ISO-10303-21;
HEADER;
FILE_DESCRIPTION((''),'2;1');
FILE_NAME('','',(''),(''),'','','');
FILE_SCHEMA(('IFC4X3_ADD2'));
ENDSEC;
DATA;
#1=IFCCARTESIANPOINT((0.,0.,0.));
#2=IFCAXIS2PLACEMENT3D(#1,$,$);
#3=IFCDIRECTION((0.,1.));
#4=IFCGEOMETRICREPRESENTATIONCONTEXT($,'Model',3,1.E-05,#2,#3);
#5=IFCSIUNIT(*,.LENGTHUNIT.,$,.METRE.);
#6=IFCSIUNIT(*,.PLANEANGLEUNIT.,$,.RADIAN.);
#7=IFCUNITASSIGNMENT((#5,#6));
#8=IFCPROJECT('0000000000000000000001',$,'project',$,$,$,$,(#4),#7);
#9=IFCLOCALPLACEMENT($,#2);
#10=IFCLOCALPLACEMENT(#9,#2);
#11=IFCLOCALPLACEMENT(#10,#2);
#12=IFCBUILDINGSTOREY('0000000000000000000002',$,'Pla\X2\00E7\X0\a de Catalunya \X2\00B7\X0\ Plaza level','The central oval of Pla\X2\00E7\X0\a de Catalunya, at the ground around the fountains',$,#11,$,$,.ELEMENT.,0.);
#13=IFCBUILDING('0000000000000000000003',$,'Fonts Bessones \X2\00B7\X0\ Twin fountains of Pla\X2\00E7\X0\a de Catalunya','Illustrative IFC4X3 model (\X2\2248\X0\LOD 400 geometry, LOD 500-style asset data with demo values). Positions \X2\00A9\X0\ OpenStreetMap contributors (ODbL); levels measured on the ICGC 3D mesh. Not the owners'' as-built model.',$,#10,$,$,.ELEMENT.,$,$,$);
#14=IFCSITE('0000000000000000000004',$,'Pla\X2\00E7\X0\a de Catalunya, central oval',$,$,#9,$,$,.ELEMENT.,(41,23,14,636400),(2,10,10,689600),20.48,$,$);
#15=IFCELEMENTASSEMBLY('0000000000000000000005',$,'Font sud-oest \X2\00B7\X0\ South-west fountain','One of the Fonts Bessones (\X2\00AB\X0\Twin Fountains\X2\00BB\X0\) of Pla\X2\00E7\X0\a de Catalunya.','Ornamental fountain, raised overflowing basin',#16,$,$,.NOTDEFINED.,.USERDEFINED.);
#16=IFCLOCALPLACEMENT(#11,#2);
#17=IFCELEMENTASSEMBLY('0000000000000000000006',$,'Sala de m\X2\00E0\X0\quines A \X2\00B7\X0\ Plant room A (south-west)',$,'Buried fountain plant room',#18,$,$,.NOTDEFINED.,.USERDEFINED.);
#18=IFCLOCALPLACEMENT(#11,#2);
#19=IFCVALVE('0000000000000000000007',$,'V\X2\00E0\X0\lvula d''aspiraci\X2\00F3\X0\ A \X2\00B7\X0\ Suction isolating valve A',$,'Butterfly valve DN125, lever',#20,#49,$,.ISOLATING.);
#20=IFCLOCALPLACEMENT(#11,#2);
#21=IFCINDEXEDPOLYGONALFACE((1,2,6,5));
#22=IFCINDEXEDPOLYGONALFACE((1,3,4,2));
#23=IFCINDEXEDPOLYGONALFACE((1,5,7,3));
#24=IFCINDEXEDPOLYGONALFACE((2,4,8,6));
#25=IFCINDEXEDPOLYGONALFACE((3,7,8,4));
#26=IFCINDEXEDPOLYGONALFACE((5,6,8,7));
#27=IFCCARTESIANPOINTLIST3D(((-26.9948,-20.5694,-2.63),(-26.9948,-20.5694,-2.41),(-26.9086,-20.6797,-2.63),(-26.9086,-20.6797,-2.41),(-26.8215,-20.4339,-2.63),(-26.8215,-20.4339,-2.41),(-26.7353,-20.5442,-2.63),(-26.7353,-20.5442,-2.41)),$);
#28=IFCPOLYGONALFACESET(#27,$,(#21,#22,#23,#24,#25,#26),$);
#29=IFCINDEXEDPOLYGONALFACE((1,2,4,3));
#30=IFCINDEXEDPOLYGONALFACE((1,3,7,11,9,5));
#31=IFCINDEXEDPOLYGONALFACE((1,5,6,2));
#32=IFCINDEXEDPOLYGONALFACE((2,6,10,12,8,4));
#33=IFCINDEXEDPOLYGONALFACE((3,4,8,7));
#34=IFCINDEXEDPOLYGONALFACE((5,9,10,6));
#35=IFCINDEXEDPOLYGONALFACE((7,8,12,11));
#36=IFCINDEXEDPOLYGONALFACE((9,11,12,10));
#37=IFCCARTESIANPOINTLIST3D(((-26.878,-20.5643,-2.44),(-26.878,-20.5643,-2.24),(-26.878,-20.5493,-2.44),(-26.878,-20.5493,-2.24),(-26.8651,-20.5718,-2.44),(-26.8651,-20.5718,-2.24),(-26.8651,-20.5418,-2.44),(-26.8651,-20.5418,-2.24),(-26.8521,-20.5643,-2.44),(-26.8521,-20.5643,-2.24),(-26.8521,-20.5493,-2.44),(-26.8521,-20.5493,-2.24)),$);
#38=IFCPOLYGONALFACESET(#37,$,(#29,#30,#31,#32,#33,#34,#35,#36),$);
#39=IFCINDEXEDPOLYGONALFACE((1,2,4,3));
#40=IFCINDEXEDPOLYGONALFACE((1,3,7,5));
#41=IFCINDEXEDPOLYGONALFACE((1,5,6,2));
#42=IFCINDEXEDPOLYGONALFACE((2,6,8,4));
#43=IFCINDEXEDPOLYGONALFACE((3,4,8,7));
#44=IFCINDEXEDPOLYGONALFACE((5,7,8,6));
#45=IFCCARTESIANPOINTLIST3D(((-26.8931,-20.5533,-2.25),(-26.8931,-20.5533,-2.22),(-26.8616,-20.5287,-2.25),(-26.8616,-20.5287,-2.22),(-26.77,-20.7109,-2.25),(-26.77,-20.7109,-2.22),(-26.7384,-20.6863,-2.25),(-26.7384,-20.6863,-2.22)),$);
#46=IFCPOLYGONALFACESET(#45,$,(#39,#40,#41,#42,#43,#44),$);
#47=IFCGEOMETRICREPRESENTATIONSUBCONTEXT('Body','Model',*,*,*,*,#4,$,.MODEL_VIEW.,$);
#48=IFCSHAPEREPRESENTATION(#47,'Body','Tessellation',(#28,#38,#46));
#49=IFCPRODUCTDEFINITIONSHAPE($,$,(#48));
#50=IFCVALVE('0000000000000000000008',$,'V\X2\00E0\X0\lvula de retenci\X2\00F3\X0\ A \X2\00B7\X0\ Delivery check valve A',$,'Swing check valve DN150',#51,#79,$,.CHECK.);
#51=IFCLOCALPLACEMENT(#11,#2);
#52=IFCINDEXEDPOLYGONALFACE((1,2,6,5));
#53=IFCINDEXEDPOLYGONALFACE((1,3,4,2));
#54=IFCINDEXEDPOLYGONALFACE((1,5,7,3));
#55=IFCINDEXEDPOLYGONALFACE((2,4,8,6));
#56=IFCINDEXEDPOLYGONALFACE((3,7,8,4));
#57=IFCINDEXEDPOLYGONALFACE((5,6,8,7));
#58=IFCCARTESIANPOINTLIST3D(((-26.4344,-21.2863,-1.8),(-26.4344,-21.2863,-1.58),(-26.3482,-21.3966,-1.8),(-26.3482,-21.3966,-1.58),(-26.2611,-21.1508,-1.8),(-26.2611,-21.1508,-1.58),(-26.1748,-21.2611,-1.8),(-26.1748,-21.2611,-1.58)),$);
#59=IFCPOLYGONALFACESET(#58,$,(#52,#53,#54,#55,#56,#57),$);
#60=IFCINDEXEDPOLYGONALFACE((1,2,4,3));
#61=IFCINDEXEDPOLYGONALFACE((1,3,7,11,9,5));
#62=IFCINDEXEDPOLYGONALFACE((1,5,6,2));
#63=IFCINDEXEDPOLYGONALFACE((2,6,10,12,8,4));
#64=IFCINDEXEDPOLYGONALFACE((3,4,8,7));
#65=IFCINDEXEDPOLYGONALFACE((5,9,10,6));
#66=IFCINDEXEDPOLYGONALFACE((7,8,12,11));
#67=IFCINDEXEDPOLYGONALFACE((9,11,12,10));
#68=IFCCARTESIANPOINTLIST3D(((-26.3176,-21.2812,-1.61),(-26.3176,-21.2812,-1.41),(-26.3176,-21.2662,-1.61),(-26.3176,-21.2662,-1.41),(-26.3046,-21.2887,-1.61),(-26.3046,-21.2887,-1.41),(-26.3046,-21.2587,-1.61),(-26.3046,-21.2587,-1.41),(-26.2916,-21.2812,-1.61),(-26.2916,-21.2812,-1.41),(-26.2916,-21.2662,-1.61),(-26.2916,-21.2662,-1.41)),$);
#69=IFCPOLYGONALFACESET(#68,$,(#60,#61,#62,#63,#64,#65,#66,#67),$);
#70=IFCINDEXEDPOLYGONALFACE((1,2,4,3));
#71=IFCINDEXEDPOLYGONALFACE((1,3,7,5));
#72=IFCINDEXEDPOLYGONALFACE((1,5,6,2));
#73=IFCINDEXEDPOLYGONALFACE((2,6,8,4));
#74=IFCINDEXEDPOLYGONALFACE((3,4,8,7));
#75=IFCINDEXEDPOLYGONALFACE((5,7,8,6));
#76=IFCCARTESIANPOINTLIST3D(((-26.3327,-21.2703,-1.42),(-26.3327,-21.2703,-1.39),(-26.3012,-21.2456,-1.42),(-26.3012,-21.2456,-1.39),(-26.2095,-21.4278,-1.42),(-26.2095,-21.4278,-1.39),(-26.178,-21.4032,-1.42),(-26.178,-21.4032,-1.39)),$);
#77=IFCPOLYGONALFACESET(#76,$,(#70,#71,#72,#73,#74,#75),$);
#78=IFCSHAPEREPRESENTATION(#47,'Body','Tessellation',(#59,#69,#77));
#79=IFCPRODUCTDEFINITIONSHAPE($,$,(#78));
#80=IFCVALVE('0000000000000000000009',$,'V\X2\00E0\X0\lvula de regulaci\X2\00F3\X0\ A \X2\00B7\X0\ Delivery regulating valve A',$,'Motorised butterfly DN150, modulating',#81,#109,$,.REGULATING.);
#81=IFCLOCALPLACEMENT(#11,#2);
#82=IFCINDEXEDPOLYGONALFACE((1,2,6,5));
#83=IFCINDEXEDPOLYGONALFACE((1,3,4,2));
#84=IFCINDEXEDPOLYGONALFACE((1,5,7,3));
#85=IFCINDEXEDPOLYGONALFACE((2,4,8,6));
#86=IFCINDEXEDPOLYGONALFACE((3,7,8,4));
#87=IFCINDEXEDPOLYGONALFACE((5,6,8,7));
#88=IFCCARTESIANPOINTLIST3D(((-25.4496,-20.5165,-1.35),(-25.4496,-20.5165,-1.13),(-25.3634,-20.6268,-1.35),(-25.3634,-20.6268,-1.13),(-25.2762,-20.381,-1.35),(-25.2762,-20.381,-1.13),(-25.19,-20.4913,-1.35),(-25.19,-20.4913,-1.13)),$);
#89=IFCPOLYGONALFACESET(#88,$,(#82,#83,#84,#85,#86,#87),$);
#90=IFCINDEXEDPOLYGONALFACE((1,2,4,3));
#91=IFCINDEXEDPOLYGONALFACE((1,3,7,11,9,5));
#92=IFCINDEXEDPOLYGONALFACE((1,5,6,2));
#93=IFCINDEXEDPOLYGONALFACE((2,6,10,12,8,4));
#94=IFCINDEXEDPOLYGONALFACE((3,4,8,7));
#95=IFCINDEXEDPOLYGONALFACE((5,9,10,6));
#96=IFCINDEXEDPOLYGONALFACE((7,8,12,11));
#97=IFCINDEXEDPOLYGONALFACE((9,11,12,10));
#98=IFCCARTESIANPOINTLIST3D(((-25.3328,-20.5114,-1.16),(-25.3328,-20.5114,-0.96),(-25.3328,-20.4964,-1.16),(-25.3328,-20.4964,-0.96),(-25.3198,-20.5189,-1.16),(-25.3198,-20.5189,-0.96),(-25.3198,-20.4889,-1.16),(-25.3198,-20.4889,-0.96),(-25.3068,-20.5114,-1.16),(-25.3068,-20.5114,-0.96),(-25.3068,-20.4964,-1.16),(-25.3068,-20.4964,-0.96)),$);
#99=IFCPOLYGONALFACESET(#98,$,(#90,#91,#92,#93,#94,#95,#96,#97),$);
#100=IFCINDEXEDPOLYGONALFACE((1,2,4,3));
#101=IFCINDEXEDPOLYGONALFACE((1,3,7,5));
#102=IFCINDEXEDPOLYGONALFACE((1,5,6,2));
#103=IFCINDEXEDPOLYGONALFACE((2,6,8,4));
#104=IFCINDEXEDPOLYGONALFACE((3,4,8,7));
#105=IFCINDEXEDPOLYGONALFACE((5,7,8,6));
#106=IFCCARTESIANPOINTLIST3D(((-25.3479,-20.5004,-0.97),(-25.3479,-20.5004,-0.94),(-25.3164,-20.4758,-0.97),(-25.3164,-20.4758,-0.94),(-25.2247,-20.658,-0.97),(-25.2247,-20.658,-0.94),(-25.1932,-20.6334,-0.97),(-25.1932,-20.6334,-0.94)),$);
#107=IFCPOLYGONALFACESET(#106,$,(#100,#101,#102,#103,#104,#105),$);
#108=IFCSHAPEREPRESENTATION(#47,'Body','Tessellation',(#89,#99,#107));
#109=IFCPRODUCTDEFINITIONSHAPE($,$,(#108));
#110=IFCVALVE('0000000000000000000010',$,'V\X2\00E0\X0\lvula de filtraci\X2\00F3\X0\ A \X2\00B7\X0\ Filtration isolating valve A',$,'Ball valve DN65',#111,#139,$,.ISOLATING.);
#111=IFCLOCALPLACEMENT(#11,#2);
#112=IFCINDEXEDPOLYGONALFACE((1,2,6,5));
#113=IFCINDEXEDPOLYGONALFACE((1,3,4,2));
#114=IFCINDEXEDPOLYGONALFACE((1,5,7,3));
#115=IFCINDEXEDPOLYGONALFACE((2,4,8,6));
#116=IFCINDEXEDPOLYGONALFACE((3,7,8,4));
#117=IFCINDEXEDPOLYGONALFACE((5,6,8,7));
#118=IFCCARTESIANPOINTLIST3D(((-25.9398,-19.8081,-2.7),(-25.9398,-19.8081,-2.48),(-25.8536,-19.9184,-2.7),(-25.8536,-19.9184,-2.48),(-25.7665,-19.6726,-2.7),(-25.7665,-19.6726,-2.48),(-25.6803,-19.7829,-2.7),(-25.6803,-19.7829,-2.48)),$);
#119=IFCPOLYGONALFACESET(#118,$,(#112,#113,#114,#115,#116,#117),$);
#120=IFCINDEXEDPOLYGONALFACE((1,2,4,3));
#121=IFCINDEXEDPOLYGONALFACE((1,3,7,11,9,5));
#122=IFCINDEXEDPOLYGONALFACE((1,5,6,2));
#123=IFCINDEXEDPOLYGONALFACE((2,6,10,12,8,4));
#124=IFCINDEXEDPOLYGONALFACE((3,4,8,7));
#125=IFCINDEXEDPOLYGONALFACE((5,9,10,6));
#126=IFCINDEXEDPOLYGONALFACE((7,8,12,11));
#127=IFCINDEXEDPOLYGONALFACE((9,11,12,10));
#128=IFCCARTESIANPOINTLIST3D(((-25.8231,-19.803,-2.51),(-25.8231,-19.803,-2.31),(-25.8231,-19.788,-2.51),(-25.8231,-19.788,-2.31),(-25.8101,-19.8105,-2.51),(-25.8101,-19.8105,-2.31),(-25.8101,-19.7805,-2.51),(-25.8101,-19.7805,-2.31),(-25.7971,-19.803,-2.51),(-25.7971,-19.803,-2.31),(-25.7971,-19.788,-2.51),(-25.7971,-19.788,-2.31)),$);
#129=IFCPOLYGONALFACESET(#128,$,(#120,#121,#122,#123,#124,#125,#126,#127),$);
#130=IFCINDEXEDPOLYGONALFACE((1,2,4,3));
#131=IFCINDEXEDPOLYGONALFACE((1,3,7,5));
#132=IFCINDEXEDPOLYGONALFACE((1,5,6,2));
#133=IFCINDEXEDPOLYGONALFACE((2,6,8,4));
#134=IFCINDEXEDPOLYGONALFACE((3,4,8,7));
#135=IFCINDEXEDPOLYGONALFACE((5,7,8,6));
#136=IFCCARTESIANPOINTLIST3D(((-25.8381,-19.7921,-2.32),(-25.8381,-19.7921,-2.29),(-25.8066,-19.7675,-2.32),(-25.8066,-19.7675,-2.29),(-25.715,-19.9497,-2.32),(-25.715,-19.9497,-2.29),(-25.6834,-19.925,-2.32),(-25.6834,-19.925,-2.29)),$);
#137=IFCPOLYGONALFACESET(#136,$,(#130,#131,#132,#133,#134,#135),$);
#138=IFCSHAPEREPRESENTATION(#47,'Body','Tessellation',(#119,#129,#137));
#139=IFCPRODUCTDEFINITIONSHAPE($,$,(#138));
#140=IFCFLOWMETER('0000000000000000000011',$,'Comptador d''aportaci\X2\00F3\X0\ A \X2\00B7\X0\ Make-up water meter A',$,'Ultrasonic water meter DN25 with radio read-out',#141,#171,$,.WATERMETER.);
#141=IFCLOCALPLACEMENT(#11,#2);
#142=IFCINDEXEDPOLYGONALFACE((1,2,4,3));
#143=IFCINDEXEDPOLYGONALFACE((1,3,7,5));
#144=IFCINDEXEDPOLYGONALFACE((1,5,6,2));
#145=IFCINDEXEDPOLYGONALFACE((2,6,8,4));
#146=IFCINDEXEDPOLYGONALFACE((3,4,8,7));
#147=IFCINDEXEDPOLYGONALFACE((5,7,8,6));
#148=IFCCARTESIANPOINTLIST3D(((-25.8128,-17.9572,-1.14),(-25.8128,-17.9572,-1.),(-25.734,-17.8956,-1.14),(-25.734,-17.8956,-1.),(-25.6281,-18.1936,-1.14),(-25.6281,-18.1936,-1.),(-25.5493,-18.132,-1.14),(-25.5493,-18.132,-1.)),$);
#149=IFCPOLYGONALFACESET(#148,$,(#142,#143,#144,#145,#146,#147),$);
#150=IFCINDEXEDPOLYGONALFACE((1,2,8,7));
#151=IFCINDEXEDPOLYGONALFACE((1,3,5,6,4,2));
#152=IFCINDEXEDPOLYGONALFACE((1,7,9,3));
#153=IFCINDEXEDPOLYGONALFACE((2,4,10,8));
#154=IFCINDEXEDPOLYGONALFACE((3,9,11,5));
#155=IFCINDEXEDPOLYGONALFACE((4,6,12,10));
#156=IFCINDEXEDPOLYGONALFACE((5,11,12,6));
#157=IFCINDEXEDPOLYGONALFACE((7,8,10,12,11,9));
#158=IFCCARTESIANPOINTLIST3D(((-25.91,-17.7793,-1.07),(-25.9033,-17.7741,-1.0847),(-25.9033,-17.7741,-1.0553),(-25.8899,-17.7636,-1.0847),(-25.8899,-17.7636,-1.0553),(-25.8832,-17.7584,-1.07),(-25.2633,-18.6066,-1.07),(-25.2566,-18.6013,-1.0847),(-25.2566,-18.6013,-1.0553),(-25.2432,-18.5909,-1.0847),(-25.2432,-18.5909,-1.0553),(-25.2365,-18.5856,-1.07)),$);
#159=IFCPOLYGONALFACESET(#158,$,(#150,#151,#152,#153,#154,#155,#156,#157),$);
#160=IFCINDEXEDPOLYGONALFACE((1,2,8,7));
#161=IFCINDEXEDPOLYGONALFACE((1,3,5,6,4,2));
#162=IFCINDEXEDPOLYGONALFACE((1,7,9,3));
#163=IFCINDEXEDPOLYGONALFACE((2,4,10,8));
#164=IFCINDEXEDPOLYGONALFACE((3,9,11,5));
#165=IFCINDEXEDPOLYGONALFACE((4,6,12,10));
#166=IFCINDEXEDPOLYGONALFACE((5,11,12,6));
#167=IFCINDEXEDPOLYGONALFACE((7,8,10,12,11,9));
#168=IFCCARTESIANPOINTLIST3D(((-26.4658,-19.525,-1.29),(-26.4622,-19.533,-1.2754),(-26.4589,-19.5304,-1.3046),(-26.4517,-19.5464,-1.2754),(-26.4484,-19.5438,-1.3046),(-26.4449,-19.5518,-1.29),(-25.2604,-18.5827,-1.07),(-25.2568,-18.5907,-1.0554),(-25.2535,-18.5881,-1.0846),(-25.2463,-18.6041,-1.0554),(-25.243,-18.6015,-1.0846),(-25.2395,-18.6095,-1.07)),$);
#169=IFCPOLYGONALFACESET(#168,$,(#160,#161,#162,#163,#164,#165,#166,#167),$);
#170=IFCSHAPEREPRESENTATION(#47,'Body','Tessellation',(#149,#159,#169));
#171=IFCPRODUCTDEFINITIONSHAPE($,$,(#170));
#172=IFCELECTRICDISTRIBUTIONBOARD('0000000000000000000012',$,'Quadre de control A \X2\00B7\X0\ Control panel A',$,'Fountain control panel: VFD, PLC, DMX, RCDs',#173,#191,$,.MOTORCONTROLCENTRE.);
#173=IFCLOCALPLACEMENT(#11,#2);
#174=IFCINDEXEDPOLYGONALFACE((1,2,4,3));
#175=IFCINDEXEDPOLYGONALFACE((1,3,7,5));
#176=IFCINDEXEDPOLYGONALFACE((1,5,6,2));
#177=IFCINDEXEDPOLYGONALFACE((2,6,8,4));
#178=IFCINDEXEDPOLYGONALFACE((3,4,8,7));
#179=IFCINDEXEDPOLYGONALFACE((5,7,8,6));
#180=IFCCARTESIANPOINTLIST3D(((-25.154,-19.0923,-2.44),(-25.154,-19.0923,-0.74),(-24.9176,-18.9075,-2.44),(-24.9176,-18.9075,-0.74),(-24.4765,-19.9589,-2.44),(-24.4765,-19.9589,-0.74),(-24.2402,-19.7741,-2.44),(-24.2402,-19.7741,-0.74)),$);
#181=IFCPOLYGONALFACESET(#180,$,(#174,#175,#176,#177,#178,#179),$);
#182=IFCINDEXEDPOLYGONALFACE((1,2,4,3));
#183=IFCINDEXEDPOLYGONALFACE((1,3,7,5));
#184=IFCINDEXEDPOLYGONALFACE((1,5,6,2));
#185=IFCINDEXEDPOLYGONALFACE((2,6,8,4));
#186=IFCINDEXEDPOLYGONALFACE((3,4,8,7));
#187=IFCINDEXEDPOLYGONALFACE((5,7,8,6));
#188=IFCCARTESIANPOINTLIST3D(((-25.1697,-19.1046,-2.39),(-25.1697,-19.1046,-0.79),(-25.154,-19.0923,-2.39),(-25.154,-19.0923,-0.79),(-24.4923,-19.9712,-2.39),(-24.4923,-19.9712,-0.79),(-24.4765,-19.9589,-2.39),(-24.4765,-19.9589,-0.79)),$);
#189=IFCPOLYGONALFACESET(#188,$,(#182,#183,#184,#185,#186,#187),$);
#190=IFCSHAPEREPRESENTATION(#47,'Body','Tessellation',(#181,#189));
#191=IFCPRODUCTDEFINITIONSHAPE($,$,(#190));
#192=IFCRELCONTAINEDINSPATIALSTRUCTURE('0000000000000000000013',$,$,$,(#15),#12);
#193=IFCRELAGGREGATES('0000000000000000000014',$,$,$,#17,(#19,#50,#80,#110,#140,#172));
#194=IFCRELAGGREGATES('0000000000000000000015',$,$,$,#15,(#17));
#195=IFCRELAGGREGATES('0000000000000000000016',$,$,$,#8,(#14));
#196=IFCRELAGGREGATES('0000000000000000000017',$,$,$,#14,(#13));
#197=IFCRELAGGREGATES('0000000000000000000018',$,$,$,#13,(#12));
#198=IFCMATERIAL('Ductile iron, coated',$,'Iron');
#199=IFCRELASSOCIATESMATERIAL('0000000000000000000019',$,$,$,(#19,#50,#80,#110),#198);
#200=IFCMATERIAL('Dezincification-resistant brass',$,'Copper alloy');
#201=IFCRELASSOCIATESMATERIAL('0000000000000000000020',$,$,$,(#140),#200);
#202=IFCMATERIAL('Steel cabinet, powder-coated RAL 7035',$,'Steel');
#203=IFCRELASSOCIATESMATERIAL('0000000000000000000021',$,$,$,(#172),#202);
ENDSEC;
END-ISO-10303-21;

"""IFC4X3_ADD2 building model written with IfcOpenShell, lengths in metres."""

from ifc_helpers import new_model, si_unit, direction, frame, frame_2d, origin, place, context, subcontext, project, spatial, polyline, rectangle, outline, extrude, material, element, aggregate, save


model = new_model("IFC4X3_ADD2")

# Units and contexts
model_context = context("Model", 3, precision=1e-05, world=origin(), true_north=direction((0.0, 1.0)))
body_context = subcontext(model_context, "Body", "Model", "MODEL_VIEW")
ifc_project = project(units=[si_unit("LENGTHUNIT", "METRE"), si_unit("PLANEANGLEUNIT", "RADIAN")], contexts=[model_context])

# Site, building, storey
site_placement = place(None, origin())
site = spatial("IfcSite", under=ifc_project, at=site_placement, Name="Plaça de Catalunya, central oval", CompositionType="ELEMENT", RefLatitude=(41, 23, 14, 636400), RefLongitude=(2, 10, 10, 689600), RefElevation=20.48)
building_placement = place(site_placement, origin())
building = spatial("IfcBuilding", under=site, at=building_placement, Name="Fonts Bessones · Twin fountains of Plaça de Catalunya", Description="Illustrative IFC4X3 model (≈LOD 400 geometry, LOD 500-style asset data with demo values). Positions © OpenStreetMap contributors (ODbL); levels measured on the ICGC 3D mesh. Not the owners' as-built model.", CompositionType="ELEMENT")
storey_placement = place(building_placement, origin())
storey = spatial("IfcBuildingStorey", under=building, at=storey_placement, Name="Plaça de Catalunya · Plaza level", Description="The central oval of Plaça de Catalunya, at the ground around the fountains", CompositionType="ELEMENT", Elevation=0.0)

# Element assemblies
assembly_1_placement = place(building_placement, origin())
assembly_1 = element("IfcElementAssembly", 1, at=assembly_1_placement, inside=storey, Name="Font sud-oest · South-west fountain", Description="One of the Fonts Bessones («Twin Fountains») of Plaça de Catalunya.", ObjectType="Ornamental fountain, raised overflowing basin", AssemblyPlace="NOTDEFINED", PredefinedType="USERDEFINED")
assembly_2_placement = place(building_placement, origin())
assembly_2 = element("IfcElementAssembly", 2, at=assembly_2_placement, Name="Sala de màquines A · Plant room A (south-west)", ObjectType="Buried fountain plant room", AssemblyPlace="NOTDEFINED", PredefinedType="USERDEFINED")

# Valves
ifc_material_1 = material(Name="Ductile iron, coated", Category="Iron")
valve_1_placement = place(building_placement, origin())
valve_1 = element("IfcValve", 3, at=valve_1_placement, material=ifc_material_1, Name="Vàlvula d'aspiració A · Suction isolating valve A", ObjectType="Butterfly valve DN125, lever", PredefinedType="ISOLATING", context=body_context, shape_type="SweptSolid", body=[
    extrude(rectangle(XDim=0.14, YDim=0.22, at=frame_2d((0.0, 0.0), x_axis=(0.615875, -0.787844))), frame((-26.8651, -20.5568, -2.63)), (0.0, 0.0, 1.0), 0.22),
    extrude(outline(polyline([(0.015, 0.0), (0.0075, 0.013), (-0.0075, 0.013), (-0.015, 0.0), (-0.0075, -0.013), (0.0075, -0.013), (0.015, 0.0)])), frame((-26.8651, -20.5568, -2.44), z_axis=(0.0, 0.0, 1.0), x_axis=(0.0, 1.0, 0.0)), (0.0, 0.0, 1.0), 0.2),
    extrude(rectangle(XDim=0.2, YDim=0.04, at=frame_2d((0.0, 0.0), x_axis=(0.615875, -0.787844))), frame((-26.8158, -20.6198, -2.25)), (0.0, 0.0, 1.0), 0.03),
])
valve_2_placement = place(building_placement, origin())
valve_2 = element("IfcValve", 4, at=valve_2_placement, material=ifc_material_1, Name="Vàlvula de retenció A · Delivery check valve A", ObjectType="Swing check valve DN150", PredefinedType="CHECK", context=body_context, shape_type="SweptSolid", body=[
    extrude(rectangle(XDim=0.14, YDim=0.22, at=frame_2d((0.0, 0.0), x_axis=(0.615875, -0.787844))), frame((-26.3046, -21.2737, -1.8)), (0.0, 0.0, 1.0), 0.22),
    extrude(outline(polyline([(0.015, 0.0), (0.0075, 0.013), (-0.0075, 0.013), (-0.015, 0.0), (-0.0075, -0.013), (0.0075, -0.013), (0.015, 0.0)])), frame((-26.3046, -21.2737, -1.61), z_axis=(0.0, 0.0, 1.0), x_axis=(0.0, 1.0, 0.0)), (0.0, 0.0, 1.0), 0.2),
    extrude(rectangle(XDim=0.2, YDim=0.04, at=frame_2d((0.0, 0.0), x_axis=(0.615875, -0.787844))), frame((-26.2553, -21.3367, -1.42)), (0.0, 0.0, 1.0), 0.03),
])
valve_3_placement = place(building_placement, origin())
valve_3 = element("IfcValve", 5, at=valve_3_placement, material=ifc_material_1, Name="Vàlvula de regulació A · Delivery regulating valve A", ObjectType="Motorised butterfly DN150, modulating", PredefinedType="REGULATING", context=body_context, shape_type="SweptSolid", body=[
    extrude(rectangle(XDim=0.14, YDim=0.22, at=frame_2d((0.0, 0.0), x_axis=(0.615875, -0.787844))), frame((-25.3198, -20.5039, -1.35)), (0.0, 0.0, 1.0), 0.22),
    extrude(outline(polyline([(0.015, 0.0), (0.0075, 0.013), (-0.0075, 0.013), (-0.015, 0.0), (-0.0075, -0.013), (0.0075, -0.013), (0.015, 0.0)])), frame((-25.3198, -20.5039, -1.16), z_axis=(0.0, 0.0, 1.0), x_axis=(0.0, 1.0, 0.0)), (0.0, 0.0, 1.0), 0.2),
    extrude(rectangle(XDim=0.2, YDim=0.04, at=frame_2d((0.0, 0.0), x_axis=(0.615875, -0.787844))), frame((-25.2705, -20.5669, -0.97)), (0.0, 0.0, 1.0), 0.03),
])
valve_4_placement = place(building_placement, origin())
valve_4 = element("IfcValve", 6, at=valve_4_placement, material=ifc_material_1, Name="Vàlvula de filtració A · Filtration isolating valve A", ObjectType="Ball valve DN65", PredefinedType="ISOLATING", context=body_context, shape_type="SweptSolid", body=[
    extrude(rectangle(XDim=0.14, YDim=0.22, at=frame_2d((0.0, 0.0), x_axis=(0.615875, -0.787844))), frame((-25.8101, -19.7955, -2.7)), (0.0, 0.0, 1.0), 0.22),
    extrude(outline(polyline([(0.015, 0.0), (0.0075, 0.013), (-0.0075, 0.013), (-0.015, 0.0), (-0.0075, -0.013), (0.0075, -0.013), (0.015, 0.0)])), frame((-25.8101, -19.7955, -2.51), z_axis=(0.0, 0.0, 1.0), x_axis=(0.0, 1.0, 0.0)), (0.0, 0.0, 1.0), 0.2),
    extrude(rectangle(XDim=0.2, YDim=0.04, at=frame_2d((0.0, 0.0), x_axis=(0.615875, -0.787844))), frame((-25.7608, -19.8586, -2.32)), (0.0, 0.0, 1.0), 0.03),
])

# Flow meter
ifc_material_2 = material(Name="Dezincification-resistant brass", Category="Copper alloy")
flow_meter_placement = place(building_placement, origin())
flow_meter = element("IfcFlowMeter", 7, at=flow_meter_placement, material=ifc_material_2, Name="Comptador d'aportació A · Make-up water meter A", ObjectType="Ultrasonic water meter DN25 with radio read-out", PredefinedType="WATERMETER", context=body_context, shape_type="SweptSolid", body=[
    extrude(rectangle(XDim=0.3, YDim=0.1, at=frame_2d((0.0, 0.0), x_axis=(0.615875, -0.787844))), frame((-25.681, -18.0446, -1.14)), (0.0, 0.0, 1.0), 0.14),
    extrude(outline(polyline([(0.017, 0.0), (0.0085, 0.0147), (-0.0085, 0.0147), (-0.017, 0.0), (-0.0085, -0.0147), (0.0085, -0.0147), (0.017, 0.0)])), frame((-25.8966, -17.7689, -1.07), z_axis=(0.615875, -0.787844, 0.0), x_axis=(-0.787844, -0.615875, 0.0)), (0.0, 0.0, 1.0), 1.05),
    extrude(outline(polyline([(0.017, 0.0), (0.0085, 0.0147), (-0.0085, 0.0147), (-0.017, 0.0), (-0.0085, -0.0147), (0.0085, -0.0147), (0.017, 0.0)])), frame((-25.2499, -18.5961, -1.07), z_axis=(-0.779823, -0.609606, -0.142327), x_axis=(-0.615875, 0.787844, 0.0)), (0.0, 0.0, 1.0), 1.5457),
])

# Electric distribution board
ifc_material_3 = material(Name="Steel cabinet, powder-coated RAL 7035", Category="Steel")
electric_distribution_board_placement = place(building_placement, origin())
electric_distribution_board = element("IfcElectricDistributionBoard", 8, at=electric_distribution_board_placement, material=ifc_material_3, Name="Quadre de control A · Control panel A", ObjectType="Fountain control panel: VFD, PLC, DMX, RCDs", PredefinedType="MOTORCONTROLCENTRE", context=body_context, shape_type="SweptSolid", body=[
    extrude(rectangle(XDim=1.1, YDim=0.3, at=frame_2d((0.0, 0.0), x_axis=(0.615875, -0.787844))), frame((-24.6971, -19.4332, -2.44)), (0.0, 0.0, 1.0), 1.7),
    extrude(rectangle(XDim=1.1, YDim=0.02, at=frame_2d((0.0, 0.0), x_axis=(0.615875, -0.787844))), frame((-24.8231, -19.5317, -2.39)), (0.0, 0.0, 1.0), 1.6),
])

aggregate(assembly_2, [valve_1, valve_2, valve_3, valve_4, flow_meter, electric_distribution_board])

aggregate(assembly_1, [assembly_2])

save(model, "model.ifc")
